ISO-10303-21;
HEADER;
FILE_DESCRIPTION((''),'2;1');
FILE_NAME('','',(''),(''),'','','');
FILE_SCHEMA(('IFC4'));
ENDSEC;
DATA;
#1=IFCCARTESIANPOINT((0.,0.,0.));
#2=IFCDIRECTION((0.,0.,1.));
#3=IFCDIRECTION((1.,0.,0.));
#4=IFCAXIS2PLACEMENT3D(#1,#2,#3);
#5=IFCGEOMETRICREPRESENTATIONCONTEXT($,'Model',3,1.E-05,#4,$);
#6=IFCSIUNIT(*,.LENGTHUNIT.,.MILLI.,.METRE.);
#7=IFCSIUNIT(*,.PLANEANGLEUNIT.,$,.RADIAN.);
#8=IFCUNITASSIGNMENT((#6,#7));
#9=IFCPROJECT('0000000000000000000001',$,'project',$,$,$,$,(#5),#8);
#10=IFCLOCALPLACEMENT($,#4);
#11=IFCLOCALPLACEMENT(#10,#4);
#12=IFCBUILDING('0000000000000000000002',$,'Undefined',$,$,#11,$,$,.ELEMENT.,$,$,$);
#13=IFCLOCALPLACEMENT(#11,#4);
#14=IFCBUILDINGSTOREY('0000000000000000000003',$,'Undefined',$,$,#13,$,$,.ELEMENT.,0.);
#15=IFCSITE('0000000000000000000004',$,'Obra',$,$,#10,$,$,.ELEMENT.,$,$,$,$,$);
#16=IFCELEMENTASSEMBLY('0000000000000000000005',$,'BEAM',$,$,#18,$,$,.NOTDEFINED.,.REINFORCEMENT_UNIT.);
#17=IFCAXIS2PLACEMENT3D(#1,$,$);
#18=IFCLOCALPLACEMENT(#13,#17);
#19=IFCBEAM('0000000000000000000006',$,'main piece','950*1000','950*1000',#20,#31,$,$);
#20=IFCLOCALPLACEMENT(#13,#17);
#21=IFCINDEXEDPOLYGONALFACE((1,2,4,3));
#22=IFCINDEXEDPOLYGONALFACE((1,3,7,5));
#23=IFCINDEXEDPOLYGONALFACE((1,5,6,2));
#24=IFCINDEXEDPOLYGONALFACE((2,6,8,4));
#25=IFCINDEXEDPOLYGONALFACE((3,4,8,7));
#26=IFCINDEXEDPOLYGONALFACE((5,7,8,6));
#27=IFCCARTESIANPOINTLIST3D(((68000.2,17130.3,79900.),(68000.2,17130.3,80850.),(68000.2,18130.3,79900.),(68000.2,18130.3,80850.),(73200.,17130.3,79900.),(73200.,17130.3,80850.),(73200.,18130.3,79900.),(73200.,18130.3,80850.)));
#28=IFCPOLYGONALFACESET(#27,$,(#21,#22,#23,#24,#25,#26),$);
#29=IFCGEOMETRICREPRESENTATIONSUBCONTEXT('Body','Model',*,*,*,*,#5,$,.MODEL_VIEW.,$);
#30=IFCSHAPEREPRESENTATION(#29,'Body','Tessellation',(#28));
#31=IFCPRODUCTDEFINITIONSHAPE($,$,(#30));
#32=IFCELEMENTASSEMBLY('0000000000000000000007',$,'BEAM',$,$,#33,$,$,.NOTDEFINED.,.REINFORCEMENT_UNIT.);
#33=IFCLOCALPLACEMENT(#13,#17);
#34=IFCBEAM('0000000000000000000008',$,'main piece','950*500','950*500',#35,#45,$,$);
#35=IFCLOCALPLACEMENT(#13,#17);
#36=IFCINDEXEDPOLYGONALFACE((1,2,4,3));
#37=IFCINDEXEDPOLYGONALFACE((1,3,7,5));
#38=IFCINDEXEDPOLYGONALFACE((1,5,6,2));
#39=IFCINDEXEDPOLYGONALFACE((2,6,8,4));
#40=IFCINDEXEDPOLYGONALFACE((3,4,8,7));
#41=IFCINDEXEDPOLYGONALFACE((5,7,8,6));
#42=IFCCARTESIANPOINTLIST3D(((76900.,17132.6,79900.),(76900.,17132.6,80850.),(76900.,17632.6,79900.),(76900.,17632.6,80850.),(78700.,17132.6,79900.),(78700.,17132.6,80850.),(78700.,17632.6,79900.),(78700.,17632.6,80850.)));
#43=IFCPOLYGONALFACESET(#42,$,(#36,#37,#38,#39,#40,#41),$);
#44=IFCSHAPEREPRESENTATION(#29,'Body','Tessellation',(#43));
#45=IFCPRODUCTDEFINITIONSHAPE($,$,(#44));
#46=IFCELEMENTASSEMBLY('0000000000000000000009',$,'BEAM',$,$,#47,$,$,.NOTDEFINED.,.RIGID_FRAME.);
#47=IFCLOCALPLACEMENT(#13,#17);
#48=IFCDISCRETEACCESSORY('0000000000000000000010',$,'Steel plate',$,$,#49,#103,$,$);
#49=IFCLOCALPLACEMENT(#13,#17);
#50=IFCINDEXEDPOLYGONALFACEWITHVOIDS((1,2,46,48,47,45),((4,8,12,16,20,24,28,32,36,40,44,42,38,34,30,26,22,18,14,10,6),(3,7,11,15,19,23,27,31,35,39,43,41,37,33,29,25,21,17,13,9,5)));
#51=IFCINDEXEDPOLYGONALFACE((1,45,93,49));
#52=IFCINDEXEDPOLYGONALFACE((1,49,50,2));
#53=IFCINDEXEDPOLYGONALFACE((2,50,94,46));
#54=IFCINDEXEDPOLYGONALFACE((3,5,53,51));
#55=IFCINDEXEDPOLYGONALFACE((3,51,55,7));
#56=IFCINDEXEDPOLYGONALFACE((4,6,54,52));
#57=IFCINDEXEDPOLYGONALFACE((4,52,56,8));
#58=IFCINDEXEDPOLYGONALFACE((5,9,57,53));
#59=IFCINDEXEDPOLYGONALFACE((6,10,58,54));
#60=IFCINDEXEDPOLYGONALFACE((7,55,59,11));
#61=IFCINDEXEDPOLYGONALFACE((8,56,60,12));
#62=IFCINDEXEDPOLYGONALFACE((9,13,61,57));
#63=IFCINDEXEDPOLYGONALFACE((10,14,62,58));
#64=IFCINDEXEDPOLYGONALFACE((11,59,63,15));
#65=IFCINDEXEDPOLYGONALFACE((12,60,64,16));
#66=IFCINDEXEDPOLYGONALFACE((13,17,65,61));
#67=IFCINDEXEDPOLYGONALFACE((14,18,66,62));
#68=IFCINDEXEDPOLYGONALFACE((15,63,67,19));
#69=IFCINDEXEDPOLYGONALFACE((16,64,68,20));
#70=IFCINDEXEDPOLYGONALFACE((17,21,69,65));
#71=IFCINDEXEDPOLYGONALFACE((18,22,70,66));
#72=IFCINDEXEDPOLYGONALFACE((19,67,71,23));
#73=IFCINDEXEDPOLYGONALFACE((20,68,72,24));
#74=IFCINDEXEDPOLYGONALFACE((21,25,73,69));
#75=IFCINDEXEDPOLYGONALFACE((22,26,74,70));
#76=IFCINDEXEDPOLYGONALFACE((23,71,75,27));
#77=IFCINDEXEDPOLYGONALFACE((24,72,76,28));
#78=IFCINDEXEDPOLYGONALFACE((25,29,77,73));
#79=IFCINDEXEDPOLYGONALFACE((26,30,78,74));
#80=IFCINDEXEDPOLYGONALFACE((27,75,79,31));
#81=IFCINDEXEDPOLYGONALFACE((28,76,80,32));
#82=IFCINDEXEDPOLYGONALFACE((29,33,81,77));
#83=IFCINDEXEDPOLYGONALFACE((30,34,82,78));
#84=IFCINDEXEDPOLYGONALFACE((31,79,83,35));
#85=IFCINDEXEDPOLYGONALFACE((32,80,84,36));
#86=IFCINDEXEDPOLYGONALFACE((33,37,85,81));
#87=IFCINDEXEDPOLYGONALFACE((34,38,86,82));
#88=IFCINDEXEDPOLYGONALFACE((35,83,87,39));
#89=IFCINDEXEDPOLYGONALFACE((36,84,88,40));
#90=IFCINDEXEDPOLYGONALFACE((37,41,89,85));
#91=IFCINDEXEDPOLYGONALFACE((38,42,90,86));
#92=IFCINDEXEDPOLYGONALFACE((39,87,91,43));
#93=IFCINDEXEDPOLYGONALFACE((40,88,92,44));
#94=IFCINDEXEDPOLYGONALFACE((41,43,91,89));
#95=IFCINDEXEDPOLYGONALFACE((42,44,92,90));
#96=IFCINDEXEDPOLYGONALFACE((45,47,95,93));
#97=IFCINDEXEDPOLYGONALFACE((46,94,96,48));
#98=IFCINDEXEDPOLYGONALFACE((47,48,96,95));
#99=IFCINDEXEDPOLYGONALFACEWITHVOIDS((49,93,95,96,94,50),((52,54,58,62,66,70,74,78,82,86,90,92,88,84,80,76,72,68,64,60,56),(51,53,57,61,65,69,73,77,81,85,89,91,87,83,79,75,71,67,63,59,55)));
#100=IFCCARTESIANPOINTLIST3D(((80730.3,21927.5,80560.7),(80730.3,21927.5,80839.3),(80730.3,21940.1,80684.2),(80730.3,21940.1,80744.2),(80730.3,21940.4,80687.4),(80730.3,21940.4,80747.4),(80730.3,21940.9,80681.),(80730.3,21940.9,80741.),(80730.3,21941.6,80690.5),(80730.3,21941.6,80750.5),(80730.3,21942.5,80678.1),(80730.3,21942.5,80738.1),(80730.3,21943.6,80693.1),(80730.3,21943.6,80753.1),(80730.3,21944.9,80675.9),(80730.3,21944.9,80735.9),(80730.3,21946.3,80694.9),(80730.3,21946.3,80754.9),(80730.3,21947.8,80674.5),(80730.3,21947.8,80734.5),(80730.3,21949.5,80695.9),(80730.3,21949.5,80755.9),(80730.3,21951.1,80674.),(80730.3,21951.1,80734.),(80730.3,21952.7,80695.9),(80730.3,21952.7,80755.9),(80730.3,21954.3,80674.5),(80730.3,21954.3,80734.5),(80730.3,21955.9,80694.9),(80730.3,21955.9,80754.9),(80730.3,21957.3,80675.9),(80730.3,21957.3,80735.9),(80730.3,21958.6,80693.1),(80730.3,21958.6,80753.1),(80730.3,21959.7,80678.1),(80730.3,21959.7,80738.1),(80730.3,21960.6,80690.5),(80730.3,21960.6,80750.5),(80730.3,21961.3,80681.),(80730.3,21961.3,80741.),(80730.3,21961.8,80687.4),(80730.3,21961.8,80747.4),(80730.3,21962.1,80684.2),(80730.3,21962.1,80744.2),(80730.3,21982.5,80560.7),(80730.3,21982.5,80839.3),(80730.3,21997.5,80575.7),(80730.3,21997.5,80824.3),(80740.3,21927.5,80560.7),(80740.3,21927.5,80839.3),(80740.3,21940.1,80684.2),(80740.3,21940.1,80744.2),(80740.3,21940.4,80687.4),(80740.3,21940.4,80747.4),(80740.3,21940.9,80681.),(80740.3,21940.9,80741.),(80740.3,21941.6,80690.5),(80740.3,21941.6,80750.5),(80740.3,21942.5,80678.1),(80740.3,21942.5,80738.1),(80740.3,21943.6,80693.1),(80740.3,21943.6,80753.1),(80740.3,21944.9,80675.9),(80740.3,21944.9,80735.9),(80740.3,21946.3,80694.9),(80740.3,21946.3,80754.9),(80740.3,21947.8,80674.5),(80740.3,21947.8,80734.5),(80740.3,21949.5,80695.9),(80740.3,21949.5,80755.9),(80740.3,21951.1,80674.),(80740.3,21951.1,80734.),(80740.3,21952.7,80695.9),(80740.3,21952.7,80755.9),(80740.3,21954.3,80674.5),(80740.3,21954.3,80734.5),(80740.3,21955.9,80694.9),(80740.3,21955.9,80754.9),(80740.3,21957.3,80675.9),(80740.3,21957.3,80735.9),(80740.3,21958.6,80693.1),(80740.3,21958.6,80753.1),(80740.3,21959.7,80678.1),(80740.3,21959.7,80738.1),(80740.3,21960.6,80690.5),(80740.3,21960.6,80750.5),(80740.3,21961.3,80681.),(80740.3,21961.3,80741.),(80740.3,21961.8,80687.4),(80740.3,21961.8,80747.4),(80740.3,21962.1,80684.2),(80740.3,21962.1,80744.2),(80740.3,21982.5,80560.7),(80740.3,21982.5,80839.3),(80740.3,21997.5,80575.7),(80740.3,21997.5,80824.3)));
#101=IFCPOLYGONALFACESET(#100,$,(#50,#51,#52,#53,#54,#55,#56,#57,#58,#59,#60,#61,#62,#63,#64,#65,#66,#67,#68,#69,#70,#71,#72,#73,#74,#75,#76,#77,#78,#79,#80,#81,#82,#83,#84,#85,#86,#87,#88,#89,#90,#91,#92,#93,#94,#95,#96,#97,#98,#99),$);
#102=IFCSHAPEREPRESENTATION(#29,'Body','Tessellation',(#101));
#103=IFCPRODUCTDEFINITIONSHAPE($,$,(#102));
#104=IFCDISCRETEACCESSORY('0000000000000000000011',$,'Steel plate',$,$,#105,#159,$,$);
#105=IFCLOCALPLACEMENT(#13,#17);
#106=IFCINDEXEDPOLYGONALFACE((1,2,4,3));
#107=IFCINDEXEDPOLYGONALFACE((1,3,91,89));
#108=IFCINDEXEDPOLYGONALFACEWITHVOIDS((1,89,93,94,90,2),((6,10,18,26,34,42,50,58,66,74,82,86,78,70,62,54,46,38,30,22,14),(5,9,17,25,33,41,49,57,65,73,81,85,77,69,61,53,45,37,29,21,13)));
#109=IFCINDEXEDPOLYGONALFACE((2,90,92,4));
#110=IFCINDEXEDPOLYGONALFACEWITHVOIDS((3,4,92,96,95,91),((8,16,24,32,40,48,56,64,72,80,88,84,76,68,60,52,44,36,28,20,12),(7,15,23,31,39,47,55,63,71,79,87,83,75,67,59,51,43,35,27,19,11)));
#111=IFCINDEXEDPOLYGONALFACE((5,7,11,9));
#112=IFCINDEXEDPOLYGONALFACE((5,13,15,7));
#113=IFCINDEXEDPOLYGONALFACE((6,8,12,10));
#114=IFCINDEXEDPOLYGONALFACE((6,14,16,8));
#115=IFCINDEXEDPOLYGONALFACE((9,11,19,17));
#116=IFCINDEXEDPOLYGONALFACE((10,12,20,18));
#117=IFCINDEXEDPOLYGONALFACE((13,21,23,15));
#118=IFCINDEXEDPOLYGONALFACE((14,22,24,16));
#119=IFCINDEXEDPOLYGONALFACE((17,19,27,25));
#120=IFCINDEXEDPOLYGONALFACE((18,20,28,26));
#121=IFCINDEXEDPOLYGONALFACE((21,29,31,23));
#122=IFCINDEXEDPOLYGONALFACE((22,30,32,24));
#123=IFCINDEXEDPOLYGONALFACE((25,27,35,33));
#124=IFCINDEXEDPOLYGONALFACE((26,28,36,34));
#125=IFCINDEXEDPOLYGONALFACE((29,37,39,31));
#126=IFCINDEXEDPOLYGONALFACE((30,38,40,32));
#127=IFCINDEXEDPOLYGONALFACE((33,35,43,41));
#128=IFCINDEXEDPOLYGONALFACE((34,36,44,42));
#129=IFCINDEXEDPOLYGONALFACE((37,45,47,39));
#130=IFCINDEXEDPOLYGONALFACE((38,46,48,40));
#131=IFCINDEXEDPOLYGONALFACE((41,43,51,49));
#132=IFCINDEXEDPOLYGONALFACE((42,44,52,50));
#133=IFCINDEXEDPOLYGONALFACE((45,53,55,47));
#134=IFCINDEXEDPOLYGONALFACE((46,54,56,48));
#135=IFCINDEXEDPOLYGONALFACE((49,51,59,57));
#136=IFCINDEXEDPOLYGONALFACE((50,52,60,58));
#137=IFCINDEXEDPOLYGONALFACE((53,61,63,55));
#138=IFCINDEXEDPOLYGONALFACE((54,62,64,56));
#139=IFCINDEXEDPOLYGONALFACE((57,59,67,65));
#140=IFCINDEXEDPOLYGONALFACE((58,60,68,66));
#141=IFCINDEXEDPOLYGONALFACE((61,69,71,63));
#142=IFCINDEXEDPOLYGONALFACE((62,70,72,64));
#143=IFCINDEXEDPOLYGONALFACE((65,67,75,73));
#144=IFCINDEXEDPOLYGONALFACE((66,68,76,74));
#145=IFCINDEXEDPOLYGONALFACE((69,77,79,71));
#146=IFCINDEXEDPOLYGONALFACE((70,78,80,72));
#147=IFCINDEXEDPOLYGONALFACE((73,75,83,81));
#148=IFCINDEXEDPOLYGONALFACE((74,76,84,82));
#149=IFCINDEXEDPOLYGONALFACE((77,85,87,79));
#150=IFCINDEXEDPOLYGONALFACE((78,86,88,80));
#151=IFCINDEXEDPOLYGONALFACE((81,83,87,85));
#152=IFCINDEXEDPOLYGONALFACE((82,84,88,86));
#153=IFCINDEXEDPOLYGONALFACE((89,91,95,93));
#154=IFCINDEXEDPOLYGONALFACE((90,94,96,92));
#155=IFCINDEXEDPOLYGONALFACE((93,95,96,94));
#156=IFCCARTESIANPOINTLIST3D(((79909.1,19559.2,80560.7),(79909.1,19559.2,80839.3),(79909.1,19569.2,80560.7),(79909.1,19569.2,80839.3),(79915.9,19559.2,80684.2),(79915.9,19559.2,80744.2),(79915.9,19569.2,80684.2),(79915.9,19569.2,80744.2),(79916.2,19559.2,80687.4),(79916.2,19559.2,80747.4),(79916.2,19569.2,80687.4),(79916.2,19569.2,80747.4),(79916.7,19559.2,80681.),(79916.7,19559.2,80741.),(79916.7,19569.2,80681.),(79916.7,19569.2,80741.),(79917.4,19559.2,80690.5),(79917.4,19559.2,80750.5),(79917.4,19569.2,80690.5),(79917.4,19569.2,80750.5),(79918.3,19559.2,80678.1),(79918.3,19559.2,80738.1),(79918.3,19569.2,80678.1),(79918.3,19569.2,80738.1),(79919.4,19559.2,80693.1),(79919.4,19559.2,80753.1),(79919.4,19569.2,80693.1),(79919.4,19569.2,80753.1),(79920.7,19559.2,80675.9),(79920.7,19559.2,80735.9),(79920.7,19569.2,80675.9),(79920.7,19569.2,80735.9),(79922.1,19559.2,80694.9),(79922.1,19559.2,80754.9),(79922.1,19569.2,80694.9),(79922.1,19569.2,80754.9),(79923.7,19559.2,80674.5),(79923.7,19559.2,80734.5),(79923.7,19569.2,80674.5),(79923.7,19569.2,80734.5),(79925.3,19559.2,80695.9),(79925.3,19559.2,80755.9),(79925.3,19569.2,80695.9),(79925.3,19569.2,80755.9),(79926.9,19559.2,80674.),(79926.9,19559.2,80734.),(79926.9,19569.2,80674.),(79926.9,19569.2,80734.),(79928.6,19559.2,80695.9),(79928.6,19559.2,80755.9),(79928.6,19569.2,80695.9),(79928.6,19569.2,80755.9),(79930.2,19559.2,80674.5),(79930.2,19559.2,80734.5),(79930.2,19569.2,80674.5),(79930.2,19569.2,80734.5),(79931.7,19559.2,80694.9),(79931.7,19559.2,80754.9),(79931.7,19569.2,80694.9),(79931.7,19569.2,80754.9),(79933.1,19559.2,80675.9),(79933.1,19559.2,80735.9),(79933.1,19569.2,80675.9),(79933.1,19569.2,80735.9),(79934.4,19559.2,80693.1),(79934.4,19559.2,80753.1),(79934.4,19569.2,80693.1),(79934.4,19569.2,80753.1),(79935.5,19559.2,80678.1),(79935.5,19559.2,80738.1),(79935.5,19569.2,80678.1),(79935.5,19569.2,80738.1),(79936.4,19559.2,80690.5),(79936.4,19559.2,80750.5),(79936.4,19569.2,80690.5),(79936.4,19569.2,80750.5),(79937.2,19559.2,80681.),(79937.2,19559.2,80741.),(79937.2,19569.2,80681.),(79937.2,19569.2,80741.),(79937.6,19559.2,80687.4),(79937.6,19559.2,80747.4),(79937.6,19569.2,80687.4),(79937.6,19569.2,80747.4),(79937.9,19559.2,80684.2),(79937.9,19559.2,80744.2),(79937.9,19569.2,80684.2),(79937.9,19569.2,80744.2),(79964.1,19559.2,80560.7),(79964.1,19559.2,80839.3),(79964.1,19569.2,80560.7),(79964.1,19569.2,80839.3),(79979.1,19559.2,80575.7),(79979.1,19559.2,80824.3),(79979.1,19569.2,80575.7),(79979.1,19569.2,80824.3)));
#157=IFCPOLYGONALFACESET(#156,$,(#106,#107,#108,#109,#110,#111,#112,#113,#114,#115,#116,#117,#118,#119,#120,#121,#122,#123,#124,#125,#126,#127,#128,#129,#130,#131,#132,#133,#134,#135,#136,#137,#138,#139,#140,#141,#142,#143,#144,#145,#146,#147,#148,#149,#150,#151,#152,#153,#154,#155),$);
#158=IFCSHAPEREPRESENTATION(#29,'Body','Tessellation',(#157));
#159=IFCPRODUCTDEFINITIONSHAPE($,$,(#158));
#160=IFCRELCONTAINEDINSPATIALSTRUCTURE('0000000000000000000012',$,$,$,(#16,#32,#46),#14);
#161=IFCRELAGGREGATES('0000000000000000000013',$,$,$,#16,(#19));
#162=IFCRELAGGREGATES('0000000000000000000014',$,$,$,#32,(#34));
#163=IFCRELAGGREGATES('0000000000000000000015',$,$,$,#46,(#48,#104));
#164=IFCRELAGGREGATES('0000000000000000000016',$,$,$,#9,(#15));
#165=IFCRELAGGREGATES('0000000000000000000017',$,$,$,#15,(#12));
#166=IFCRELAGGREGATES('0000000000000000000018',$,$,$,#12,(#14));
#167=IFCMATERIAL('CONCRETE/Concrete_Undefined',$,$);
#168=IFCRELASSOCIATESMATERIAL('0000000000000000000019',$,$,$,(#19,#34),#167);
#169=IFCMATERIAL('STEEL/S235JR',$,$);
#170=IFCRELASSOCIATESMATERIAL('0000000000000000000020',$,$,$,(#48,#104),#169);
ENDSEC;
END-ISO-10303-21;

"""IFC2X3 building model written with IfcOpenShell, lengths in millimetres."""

from ifc_helpers import new_model, si_unit, frame, origin_with_axes, origin_2d_with_axis, place, context, subcontext, project, spatial, polyline, rectangle, circle, outline, extrude, source, transform, mapped, material, element, aggregate, save


model = new_model("IFC2X3")

# Units and contexts
model_context = context("Model", 3, precision=1e-05, world=origin_with_axes())
body_context = subcontext(model_context, "Body", "Model", "MODEL_VIEW")
ifc_project = project(units=[si_unit("LENGTHUNIT", "METRE", prefix="MILLI"), si_unit("PLANEANGLEUNIT", "RADIAN")], contexts=[model_context])

# Site, building, storey
site_placement = place(None, origin_with_axes())
site = spatial("IfcSite", under=ifc_project, at=site_placement, Name="Obra", CompositionType="ELEMENT")
building_placement = place(site_placement, origin_with_axes())
building = spatial("IfcBuilding", under=site, at=building_placement, Name="Undefined", CompositionType="ELEMENT")
storey_placement = place(building_placement, origin_with_axes())
storey = spatial("IfcBuildingStorey", under=building, at=storey_placement, Name="Undefined", CompositionType="ELEMENT", Elevation=0.0)

# Shared definitions
ifc_material_1 = material(Name="STEEL/S235JR")

# Element assemblies, beams
assembly_1_placement = place(storey_placement, origin_with_axes())
assembly_1 = element("IfcElementAssembly", 1, at=assembly_1_placement, inside=storey, Name="BEAM", AssemblyPlace="NOTDEFINED", PredefinedType="REINFORCEMENT_UNIT")
ifc_material_2 = material(Name="CONCRETE/Concrete_Undefined")
beam_1_placement = place(assembly_1_placement, frame((68000.2, 17630.3, 80375.0), z_axis=(0.0, 0.0, 1.0), x_axis=(1.0, 0.0, 0.0)))
beam_1 = element("IfcBeam", 2, at=beam_1_placement, material=ifc_material_2, Name="main piece", Description="950*1000", ObjectType="950*1000", context=body_context, shape_type="SweptSolid", body=[
    extrude(rectangle(XDim=1000.0, YDim=950.0, at=origin_2d_with_axis()), frame((5199.8, 0.0, 0.0), z_axis=(-1.0, 0.0, 0.0), x_axis=(0.0, -1.0, 0.0)), (0.0, 0.0, 1.0), 5199.8),
])
aggregate(assembly_1, [beam_1])
assembly_2_placement = place(storey_placement, origin_with_axes())
assembly_2 = element("IfcElementAssembly", 3, at=assembly_2_placement, inside=storey, Name="BEAM", AssemblyPlace="NOTDEFINED", PredefinedType="REINFORCEMENT_UNIT")
beam_2_placement = place(assembly_2_placement, frame((78700.0, 17382.6, 80375.0), z_axis=(0.0, 0.0, 1.0), x_axis=(-1.0, 0.0, 0.0)))
beam_2 = element("IfcBeam", 4, at=beam_2_placement, material=ifc_material_2, Name="main piece", Description="950*500", ObjectType="950*500", context=body_context, shape_type="SweptSolid", body=[
    extrude(rectangle(XDim=500.0, YDim=950.0, at=origin_2d_with_axis()), frame((1800.0, 0.0, 0.0), z_axis=(-1.0, 0.0, 0.0), x_axis=(0.0, -1.0, 0.0)), (0.0, 0.0, 1.0), 1800.0),
])
aggregate(assembly_2, [beam_2])

# Element assembly, discrete accessories, openings
assembly_3_placement = place(storey_placement, origin_with_axes())
assembly_3 = element("IfcElementAssembly", 5, at=assembly_3_placement, inside=storey, Name="BEAM", AssemblyPlace="NOTDEFINED", PredefinedType="RIGID_FRAME")
discrete_accessory_1_placement = place(assembly_3_placement, frame((80735.3, 21927.5, 80560.7), z_axis=(1.0, 0.0, 0.0), x_axis=(0.0, 1.0, 0.0)))
discrete_accessory_1 = element("IfcDiscreteAccessory", 6, at=discrete_accessory_1_placement, material=ifc_material_1, Name="Steel plate", context=body_context, shape_type="SweptSolid", body=[
    extrude(outline(polyline([(0.0, 0.0), (55.0, 0.0), (70.0, 15.0), (70.0, 263.6), (55.0, 278.6), (0.0, 278.6), (0.0, 0.0)])), frame((0.0, 0.0, -5.0), z_axis=(0.0, 0.0, 1.0), x_axis=(1.0, 0.0, 0.0)), (0.0, 0.0, 1.0), 10.0),
])
shared_shape_1 = source(origin_with_axes(), body_context, "Body", "SweptSolid", [
    extrude(circle(Radius=11.0, at=origin_2d_with_axis()), frame((0.0, -5.1, 0.0), z_axis=(0.0, 1.0, 0.0), x_axis=(1.0, 0.0, 0.0)), (0.0, 0.0, 1.0), 10.2),
])
opening_1_placement = place(assembly_3_placement, frame((80735.3, 21991.1, 80850.0), z_axis=(0.0, -1.0, 0.0), x_axis=(0.0, 0.0, -1.0)))
element("IfcOpeningElement", 7, at=opening_1_placement, cuts=discrete_accessory_1, ObjectType="Opening", context=body_context, shape_type="MappedRepresentation", body=[
    mapped(shared_shape_1, transform((105.0, 0.0, 40.0))),
    mapped(shared_shape_1, transform((165.0, 0.0, 40.0))),
])
discrete_accessory_2_placement = place(assembly_3_placement, frame((79909.1, 19564.2, 80560.7), z_axis=(0.0, -1.0, 0.0), x_axis=(1.0, 0.0, 0.0)))
discrete_accessory_2 = element("IfcDiscreteAccessory", 8, at=discrete_accessory_2_placement, material=ifc_material_1, Name="Steel plate", context=body_context, shape_type="SweptSolid", body=[
    extrude(outline(polyline([(0.0, 0.0), (55.0, 0.0), (70.0, 15.0), (70.0, 263.6), (55.0, 278.6), (0.0, 278.6), (0.0, 0.0)])), frame((0.0, 0.0, -5.0), z_axis=(0.0, 0.0, 1.0), x_axis=(1.0, 0.0, 0.0)), (0.0, 0.0, 1.0), 10.0),
])
shared_shape_2 = source(origin_with_axes(), body_context, "Body", "SweptSolid", [
    extrude(circle(Radius=11.0, at=origin_2d_with_axis()), frame((0.0, -11.6, 0.0), z_axis=(0.0, 1.0, 0.0), x_axis=(1.0, 0.0, 0.0)), (0.0, 0.0, 1.0), 10.2),
])
opening_2_placement = place(assembly_3_placement, frame((79966.9, 19557.6, 80850.0), z_axis=(-1.0, 0.0, 0.0), x_axis=(0.0, 0.0, -1.0)))
element("IfcOpeningElement", 9, at=opening_2_placement, cuts=discrete_accessory_2, ObjectType="Opening", context=body_context, shape_type="MappedRepresentation", body=[
    mapped(shared_shape_2, transform((105.0, 0.0, 40.0))),
    mapped(shared_shape_2, transform((165.0, 0.0, 40.0))),
])
aggregate(assembly_3, [discrete_accessory_1, discrete_accessory_2])

save(model, "model.ifc")
